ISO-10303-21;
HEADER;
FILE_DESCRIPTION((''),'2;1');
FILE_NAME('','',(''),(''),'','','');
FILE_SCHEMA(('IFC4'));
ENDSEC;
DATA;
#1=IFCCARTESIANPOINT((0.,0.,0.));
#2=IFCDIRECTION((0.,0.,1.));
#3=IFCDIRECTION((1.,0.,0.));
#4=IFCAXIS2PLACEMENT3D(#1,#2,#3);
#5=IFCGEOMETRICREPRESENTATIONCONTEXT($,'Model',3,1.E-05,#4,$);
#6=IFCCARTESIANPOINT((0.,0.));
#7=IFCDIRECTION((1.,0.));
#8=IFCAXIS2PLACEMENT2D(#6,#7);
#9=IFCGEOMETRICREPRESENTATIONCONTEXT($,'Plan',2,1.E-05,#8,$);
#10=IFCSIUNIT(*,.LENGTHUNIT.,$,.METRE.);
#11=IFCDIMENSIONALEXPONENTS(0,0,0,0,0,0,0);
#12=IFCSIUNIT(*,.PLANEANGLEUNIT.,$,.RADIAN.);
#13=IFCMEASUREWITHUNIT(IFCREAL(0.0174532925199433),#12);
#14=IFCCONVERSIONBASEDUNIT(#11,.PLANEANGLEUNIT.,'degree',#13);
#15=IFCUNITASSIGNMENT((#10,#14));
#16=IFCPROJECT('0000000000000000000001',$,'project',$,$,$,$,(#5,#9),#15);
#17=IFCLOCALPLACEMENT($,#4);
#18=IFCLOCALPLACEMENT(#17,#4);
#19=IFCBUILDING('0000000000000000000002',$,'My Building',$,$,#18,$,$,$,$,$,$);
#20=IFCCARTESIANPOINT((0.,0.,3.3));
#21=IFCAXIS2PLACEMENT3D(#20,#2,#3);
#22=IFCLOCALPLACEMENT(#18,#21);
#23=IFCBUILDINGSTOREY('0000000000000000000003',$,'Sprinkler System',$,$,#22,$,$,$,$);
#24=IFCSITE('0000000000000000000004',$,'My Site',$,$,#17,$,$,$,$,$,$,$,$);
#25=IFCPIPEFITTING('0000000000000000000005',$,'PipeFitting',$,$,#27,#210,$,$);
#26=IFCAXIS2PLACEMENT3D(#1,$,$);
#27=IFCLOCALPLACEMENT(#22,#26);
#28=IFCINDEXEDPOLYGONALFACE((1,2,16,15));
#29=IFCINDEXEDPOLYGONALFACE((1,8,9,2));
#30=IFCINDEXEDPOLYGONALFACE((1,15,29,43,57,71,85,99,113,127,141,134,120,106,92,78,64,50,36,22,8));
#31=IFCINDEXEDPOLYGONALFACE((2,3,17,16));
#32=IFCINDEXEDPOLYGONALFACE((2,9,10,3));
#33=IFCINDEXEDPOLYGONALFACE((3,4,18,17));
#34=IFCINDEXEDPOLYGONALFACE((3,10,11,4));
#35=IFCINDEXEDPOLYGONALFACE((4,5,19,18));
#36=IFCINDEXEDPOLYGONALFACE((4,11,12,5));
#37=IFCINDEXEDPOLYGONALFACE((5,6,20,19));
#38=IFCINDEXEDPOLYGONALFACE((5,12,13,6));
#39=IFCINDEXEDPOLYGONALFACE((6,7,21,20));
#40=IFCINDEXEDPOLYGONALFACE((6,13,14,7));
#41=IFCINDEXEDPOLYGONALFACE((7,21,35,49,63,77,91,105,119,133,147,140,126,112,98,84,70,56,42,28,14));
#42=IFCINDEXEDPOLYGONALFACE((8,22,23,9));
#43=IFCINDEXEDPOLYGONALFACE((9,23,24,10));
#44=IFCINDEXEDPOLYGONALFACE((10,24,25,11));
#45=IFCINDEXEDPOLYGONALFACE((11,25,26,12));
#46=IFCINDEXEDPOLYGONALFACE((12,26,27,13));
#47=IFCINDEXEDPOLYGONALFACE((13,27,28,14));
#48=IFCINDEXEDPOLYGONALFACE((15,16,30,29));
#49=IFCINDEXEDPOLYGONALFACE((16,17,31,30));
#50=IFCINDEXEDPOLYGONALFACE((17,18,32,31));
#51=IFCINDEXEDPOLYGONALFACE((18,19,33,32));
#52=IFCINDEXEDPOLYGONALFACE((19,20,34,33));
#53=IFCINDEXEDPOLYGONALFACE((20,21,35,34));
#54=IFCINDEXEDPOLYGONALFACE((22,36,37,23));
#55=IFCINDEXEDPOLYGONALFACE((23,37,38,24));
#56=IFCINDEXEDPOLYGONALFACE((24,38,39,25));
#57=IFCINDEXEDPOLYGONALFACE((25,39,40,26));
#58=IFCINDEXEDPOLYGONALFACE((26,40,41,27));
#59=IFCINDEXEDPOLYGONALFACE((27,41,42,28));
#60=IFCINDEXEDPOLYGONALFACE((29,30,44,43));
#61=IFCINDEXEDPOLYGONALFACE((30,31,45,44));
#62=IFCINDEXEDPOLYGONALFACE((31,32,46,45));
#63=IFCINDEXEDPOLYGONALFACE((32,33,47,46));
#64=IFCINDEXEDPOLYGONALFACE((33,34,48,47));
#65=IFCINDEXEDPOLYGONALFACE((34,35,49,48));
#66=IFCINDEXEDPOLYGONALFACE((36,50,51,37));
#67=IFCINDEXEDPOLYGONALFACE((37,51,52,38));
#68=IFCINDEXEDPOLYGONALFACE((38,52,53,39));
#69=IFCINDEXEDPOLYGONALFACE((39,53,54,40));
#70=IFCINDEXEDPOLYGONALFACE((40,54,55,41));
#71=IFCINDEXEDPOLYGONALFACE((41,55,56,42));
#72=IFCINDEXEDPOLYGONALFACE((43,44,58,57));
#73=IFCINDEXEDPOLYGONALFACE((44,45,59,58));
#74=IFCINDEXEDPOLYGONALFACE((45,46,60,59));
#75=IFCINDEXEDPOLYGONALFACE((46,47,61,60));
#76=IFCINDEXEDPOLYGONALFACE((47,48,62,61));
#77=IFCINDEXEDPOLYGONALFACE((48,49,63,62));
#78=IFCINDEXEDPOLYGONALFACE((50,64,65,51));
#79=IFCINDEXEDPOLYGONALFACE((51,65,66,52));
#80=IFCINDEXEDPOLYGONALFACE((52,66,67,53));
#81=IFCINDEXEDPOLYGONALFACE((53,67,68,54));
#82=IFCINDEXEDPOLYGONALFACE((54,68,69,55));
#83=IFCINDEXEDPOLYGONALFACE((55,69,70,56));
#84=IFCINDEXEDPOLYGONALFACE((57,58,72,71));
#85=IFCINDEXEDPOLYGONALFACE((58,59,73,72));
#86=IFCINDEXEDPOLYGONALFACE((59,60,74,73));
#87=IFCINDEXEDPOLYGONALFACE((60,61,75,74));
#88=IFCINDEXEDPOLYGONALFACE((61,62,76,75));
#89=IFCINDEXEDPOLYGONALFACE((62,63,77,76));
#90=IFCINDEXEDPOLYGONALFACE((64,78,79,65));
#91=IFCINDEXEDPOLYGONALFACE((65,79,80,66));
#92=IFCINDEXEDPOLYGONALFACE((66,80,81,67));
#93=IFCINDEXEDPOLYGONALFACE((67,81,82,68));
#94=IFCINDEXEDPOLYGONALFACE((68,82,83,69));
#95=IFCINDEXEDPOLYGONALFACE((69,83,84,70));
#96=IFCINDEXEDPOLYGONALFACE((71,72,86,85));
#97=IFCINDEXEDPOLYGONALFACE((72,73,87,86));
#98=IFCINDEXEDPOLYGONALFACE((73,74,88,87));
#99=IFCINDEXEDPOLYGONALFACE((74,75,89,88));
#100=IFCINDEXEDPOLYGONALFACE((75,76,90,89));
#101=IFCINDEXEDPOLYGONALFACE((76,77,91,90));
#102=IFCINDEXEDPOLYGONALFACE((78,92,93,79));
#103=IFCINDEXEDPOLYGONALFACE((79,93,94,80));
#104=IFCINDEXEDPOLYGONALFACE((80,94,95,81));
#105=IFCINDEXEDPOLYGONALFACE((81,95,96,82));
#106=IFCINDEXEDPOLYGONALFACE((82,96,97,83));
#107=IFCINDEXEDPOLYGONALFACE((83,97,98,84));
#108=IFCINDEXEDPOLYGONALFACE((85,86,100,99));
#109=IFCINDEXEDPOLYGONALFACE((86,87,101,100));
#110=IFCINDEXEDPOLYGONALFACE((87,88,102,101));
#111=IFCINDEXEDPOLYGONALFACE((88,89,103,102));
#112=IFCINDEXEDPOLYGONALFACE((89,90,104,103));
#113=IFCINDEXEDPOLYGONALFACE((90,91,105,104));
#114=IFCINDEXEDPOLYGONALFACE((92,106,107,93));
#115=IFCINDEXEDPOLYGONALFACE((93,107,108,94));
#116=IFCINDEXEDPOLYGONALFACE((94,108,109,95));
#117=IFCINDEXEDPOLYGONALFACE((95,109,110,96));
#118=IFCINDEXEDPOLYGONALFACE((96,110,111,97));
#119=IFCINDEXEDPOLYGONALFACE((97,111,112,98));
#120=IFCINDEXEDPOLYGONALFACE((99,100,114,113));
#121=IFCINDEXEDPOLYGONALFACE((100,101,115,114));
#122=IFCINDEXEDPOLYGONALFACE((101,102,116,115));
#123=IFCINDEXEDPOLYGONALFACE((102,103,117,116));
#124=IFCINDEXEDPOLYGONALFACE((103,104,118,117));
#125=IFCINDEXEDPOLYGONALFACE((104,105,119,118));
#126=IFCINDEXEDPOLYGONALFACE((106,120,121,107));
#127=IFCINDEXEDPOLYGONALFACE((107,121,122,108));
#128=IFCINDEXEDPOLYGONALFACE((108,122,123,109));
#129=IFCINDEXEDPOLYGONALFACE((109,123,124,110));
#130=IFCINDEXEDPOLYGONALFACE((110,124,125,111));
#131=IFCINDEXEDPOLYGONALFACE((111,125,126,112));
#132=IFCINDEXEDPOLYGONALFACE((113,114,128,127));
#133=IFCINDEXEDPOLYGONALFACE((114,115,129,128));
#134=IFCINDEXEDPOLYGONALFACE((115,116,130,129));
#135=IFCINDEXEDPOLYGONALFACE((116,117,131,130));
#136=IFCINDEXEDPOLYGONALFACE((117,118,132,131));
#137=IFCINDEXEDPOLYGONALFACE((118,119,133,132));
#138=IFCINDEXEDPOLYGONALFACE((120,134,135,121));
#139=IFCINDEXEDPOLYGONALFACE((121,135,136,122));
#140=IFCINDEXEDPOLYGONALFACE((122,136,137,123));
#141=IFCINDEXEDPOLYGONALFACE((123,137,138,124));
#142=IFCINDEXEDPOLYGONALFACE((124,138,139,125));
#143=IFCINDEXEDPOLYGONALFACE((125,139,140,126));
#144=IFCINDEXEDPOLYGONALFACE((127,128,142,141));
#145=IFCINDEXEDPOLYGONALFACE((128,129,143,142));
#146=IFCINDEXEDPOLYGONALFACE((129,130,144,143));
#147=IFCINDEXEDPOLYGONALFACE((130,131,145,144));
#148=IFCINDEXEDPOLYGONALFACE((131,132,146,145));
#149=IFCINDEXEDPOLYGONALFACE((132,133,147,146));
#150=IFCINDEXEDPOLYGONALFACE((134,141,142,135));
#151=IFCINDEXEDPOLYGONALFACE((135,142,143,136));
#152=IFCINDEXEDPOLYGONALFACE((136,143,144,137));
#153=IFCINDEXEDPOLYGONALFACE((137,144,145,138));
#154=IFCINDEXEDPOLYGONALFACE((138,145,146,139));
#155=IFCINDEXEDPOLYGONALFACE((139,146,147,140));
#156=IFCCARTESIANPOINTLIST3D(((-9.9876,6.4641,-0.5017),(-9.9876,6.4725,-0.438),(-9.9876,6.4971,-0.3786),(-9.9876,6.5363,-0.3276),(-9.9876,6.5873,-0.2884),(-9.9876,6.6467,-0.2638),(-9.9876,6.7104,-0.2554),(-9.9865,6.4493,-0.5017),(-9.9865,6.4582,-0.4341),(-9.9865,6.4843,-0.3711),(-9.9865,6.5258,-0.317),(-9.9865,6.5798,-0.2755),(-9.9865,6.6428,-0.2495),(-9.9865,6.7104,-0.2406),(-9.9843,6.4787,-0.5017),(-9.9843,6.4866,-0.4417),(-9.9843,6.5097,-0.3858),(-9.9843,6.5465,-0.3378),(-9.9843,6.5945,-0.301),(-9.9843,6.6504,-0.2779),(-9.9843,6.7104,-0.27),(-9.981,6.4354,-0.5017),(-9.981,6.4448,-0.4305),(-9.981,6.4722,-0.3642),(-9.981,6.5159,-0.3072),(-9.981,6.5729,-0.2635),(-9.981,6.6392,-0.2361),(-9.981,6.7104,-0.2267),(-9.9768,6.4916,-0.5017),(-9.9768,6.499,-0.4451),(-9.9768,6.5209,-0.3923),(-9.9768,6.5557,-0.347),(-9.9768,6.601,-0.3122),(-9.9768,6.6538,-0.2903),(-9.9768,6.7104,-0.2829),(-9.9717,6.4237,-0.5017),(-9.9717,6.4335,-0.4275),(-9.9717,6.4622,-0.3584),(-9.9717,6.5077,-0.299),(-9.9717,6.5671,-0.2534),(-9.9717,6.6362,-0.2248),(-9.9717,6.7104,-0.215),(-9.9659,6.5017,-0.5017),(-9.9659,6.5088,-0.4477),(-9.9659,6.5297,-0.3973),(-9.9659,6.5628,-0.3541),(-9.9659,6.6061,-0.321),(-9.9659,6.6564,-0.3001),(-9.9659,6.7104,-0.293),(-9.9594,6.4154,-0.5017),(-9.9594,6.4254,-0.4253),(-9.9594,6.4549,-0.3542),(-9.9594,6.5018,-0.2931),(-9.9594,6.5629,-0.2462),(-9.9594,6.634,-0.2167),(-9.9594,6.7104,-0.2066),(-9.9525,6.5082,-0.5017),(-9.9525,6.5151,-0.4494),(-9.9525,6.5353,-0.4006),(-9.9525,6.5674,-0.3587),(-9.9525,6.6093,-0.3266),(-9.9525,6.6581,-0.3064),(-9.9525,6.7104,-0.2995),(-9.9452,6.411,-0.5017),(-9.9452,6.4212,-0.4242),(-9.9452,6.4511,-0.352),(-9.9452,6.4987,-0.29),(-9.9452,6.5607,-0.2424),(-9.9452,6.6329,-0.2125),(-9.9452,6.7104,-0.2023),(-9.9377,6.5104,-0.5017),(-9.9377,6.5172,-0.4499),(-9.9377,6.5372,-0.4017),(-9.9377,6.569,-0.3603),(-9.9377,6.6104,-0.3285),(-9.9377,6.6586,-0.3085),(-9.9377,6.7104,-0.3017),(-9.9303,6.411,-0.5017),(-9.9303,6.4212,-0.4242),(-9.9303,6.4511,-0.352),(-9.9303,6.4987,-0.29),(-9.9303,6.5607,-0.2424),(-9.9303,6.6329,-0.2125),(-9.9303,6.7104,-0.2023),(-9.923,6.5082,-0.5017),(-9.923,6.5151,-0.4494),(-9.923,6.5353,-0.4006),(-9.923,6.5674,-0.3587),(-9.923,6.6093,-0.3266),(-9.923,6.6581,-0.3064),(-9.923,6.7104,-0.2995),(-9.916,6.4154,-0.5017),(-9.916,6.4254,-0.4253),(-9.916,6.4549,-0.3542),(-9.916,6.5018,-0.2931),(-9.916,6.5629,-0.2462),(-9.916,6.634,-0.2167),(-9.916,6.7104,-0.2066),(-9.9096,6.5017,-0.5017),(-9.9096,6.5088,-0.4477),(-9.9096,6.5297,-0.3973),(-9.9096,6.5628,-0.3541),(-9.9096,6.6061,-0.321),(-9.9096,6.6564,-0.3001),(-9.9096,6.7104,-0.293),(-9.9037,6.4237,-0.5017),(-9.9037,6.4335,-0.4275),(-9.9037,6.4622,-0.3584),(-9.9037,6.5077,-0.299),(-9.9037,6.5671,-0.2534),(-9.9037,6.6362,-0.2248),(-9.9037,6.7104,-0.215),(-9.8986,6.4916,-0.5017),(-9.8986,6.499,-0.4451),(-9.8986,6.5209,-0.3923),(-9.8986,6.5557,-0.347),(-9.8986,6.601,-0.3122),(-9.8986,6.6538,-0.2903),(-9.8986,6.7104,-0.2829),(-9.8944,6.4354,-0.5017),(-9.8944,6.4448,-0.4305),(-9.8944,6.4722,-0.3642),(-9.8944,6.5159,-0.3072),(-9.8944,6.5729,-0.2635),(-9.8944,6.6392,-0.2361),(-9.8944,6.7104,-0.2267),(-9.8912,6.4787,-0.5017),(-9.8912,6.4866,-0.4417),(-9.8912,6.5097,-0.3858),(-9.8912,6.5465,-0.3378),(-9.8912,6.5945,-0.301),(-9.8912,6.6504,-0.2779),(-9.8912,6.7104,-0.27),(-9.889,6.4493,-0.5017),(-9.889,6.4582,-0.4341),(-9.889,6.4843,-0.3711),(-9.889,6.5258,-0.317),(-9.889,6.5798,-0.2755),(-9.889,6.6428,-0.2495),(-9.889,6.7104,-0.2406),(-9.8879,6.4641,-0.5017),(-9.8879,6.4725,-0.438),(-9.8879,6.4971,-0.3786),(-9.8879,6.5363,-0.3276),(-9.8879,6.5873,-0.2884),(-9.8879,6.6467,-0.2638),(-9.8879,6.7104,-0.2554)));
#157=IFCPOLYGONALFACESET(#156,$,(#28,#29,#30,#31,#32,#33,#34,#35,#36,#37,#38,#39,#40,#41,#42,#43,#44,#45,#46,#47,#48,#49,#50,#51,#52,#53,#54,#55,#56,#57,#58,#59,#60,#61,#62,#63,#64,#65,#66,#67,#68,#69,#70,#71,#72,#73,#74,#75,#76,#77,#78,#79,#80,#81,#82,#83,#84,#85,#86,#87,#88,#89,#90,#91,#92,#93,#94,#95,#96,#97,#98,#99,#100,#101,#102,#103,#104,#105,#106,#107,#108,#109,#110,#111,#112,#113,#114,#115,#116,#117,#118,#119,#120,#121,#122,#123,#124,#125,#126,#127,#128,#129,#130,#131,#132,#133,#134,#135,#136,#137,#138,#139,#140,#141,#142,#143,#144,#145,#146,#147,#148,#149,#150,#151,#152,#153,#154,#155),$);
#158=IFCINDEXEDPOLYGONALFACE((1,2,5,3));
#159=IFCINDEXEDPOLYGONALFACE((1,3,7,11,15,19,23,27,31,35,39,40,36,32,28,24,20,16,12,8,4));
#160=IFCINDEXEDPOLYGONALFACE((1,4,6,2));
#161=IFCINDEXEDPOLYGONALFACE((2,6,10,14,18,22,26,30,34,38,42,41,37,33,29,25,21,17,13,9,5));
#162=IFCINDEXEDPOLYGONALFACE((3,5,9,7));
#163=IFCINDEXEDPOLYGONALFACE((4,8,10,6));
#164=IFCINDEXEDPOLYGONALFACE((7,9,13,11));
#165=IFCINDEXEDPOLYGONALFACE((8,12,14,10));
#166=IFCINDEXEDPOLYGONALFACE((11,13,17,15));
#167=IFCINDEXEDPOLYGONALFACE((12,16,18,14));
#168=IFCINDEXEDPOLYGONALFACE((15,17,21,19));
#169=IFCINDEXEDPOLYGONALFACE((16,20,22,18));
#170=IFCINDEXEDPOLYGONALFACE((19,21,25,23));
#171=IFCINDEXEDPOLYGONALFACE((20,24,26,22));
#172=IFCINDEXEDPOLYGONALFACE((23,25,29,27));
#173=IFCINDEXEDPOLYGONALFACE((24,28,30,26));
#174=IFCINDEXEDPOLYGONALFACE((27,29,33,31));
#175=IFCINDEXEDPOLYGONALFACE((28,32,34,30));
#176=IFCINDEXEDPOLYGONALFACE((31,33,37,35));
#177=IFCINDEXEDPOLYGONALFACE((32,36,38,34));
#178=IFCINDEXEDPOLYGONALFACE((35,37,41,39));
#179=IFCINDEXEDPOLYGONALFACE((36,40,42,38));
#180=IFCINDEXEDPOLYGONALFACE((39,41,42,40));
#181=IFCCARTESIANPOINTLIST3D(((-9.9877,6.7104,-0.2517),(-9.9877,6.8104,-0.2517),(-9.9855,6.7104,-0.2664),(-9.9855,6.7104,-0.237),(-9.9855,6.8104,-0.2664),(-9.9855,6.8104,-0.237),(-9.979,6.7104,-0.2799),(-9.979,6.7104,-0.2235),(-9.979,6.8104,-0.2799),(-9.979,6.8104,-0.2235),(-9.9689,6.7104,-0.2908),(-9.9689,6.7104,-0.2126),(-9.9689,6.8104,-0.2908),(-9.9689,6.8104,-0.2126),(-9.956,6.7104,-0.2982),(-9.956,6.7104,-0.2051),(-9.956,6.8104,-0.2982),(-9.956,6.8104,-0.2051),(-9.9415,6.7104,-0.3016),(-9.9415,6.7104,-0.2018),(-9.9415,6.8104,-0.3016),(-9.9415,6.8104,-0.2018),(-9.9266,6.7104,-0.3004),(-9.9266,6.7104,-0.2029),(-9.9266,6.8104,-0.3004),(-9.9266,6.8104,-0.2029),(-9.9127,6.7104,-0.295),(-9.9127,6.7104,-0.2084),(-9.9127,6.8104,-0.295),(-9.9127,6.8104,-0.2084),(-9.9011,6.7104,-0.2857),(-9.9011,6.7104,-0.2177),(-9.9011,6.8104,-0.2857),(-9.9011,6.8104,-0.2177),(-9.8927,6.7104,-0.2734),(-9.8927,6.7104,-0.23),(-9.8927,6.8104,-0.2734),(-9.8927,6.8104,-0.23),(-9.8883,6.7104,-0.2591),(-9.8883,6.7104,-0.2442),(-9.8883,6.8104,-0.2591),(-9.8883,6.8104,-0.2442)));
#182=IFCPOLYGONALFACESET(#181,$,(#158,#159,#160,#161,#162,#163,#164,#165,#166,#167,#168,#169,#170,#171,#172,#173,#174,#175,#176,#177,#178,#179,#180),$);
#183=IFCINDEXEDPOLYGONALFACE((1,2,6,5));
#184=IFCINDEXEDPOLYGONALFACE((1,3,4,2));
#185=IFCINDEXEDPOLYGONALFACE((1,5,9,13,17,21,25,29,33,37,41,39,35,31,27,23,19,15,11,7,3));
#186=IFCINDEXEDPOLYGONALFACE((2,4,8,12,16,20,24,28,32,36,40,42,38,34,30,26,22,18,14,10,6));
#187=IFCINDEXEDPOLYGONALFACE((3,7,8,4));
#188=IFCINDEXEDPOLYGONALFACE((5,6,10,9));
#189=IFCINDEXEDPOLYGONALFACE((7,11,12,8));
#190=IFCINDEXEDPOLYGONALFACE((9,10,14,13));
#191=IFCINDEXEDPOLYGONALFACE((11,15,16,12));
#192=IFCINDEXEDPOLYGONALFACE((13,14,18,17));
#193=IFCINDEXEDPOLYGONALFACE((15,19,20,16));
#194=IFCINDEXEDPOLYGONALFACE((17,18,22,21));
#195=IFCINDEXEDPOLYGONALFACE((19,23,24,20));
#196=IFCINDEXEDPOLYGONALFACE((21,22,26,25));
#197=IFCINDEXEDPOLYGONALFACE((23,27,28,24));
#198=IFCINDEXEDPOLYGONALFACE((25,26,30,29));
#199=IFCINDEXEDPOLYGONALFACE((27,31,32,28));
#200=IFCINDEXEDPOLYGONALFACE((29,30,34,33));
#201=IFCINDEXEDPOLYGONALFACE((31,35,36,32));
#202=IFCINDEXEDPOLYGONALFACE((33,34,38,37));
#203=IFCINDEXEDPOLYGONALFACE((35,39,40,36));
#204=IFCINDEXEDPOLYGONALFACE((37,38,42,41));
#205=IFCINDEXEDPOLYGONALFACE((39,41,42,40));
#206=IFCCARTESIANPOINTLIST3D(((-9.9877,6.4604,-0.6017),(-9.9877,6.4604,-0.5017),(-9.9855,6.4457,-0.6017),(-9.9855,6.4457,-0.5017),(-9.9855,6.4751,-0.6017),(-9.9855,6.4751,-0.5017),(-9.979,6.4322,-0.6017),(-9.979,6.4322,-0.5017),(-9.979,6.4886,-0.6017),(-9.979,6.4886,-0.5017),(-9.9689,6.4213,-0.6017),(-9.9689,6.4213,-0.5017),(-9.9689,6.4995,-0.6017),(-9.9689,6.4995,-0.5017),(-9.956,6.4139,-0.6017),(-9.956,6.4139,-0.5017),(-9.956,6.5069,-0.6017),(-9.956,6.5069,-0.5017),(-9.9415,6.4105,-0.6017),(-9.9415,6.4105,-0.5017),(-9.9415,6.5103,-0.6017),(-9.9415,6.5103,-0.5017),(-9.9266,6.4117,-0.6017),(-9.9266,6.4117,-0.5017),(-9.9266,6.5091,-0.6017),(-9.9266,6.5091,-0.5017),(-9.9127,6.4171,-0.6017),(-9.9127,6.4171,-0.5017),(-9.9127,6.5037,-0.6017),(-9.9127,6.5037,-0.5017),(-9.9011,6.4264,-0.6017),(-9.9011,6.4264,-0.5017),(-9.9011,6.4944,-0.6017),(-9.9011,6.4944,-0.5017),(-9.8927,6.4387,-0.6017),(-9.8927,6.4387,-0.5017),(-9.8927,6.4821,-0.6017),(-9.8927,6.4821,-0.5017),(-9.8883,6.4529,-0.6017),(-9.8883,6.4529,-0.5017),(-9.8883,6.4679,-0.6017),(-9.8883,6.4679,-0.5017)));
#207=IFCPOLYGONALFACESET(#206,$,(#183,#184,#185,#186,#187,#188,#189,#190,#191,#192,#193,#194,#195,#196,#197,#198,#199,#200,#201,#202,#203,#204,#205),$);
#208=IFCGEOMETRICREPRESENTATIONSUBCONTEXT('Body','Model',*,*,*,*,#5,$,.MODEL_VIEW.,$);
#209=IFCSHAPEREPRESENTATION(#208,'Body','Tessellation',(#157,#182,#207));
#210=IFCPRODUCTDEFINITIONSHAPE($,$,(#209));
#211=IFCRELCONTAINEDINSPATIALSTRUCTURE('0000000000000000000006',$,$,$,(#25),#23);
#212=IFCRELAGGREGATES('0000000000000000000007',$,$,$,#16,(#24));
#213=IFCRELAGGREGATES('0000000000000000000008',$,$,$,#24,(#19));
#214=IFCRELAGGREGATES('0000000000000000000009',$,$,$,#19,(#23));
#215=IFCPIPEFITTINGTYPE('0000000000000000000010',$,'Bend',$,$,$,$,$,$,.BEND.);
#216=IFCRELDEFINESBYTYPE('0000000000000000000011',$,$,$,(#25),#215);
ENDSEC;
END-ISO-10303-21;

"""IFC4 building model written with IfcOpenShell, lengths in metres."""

from ifc_helpers import new_model, entity, si_unit, converted_unit, frame, origin_with_axes, origin_2d_with_axis, place, context, subcontext, project, spatial, circle, extrude, source, transform, mapped, type_object, type_shapes, element, save


model = new_model("IFC4")

# Units and contexts
model_context = context("Model", 3, precision=1e-05, world=origin_with_axes())
plan_context = context("Plan", 2, precision=1e-05, world=origin_2d_with_axis())
body_context = subcontext(model_context, "Body", "Model", "MODEL_VIEW")
ifc_project = project(units=[si_unit("LENGTHUNIT", "METRE"), converted_unit("PLANEANGLEUNIT", "degree", entity("IfcReal", 0.0174532925199433), si_unit("PLANEANGLEUNIT", "RADIAN"), dimensions=[0, 0, 0, 0, 0, 0, 0])], contexts=[model_context, plan_context])

# Site, building, storey
site_placement = place(None, origin_with_axes())
site = spatial("IfcSite", under=ifc_project, at=site_placement, Name="My Site")
building_placement = place(site_placement, origin_with_axes())
building = spatial("IfcBuilding", under=site, at=building_placement, Name="My Building")
storey_placement = place(building_placement, frame((0.0, 0.0, 3.3), z_axis=(0.0, 0.0, 1.0), x_axis=(1.0, 0.0, 0.0)))
storey = spatial("IfcBuildingStorey", under=building, at=storey_placement, Name="Sprinkler System")

# Pipe fitting
pipe_fitting_type_1 = type_object("IfcPipeFittingType", Name="Bend", PredefinedType="BEND")
shared_shape_1 = source(origin_with_axes(), body_context, "Body", "SolidModel", [
    entity("IfcSweptDiskSolid", entity("IfcIndexedPolyCurve", entity("IfcCartesianPointList3D", [[0.0, 0.0, -0.1], [0.0, -0.0732, -0.2768], [0.0, -0.25, -0.35]]), [entity("IfcArcIndex", [1, 2, 3])]), 0.05),
    extrude(circle(Radius=0.05), origin_with_axes(), (0.0, 0.0, -1.0), 0.1),
    extrude(circle(Radius=0.05), frame((0.0, -0.25, -0.35), z_axis=(0.0, -1.0, 0.000012), x_axis=(1.0, 0.0, 0.0)), (0.0, 0.0, 1.0), 0.1),
])
type_shapes(pipe_fitting_type_1, [shared_shape_1])
for number, where, z_axis, x_axis, name in (
    (1, (-9.9377, 6.8104, -0.2517), (0.0, 1.0, -0.000012), (-1.0, 0.0, 0.0), "PipeFitting"),
):
    element("IfcPipeFitting", number, at=place(storey_placement, frame(where, z_axis=z_axis, x_axis=x_axis)), inside=storey, type_object=pipe_fitting_type_1, Name=name, context=body_context, shape_type="MappedRepresentation", body=[
        mapped(shared_shape_1, transform((0.0, 0.0, 0.0), x_axis=(1.0, 0.0, 0.0), y_axis=(0.0, 1.0, 0.0), z_axis=(0.0, 0.0, 1.0), scale=1.0)),
    ])

save(model, "model.ifc")
